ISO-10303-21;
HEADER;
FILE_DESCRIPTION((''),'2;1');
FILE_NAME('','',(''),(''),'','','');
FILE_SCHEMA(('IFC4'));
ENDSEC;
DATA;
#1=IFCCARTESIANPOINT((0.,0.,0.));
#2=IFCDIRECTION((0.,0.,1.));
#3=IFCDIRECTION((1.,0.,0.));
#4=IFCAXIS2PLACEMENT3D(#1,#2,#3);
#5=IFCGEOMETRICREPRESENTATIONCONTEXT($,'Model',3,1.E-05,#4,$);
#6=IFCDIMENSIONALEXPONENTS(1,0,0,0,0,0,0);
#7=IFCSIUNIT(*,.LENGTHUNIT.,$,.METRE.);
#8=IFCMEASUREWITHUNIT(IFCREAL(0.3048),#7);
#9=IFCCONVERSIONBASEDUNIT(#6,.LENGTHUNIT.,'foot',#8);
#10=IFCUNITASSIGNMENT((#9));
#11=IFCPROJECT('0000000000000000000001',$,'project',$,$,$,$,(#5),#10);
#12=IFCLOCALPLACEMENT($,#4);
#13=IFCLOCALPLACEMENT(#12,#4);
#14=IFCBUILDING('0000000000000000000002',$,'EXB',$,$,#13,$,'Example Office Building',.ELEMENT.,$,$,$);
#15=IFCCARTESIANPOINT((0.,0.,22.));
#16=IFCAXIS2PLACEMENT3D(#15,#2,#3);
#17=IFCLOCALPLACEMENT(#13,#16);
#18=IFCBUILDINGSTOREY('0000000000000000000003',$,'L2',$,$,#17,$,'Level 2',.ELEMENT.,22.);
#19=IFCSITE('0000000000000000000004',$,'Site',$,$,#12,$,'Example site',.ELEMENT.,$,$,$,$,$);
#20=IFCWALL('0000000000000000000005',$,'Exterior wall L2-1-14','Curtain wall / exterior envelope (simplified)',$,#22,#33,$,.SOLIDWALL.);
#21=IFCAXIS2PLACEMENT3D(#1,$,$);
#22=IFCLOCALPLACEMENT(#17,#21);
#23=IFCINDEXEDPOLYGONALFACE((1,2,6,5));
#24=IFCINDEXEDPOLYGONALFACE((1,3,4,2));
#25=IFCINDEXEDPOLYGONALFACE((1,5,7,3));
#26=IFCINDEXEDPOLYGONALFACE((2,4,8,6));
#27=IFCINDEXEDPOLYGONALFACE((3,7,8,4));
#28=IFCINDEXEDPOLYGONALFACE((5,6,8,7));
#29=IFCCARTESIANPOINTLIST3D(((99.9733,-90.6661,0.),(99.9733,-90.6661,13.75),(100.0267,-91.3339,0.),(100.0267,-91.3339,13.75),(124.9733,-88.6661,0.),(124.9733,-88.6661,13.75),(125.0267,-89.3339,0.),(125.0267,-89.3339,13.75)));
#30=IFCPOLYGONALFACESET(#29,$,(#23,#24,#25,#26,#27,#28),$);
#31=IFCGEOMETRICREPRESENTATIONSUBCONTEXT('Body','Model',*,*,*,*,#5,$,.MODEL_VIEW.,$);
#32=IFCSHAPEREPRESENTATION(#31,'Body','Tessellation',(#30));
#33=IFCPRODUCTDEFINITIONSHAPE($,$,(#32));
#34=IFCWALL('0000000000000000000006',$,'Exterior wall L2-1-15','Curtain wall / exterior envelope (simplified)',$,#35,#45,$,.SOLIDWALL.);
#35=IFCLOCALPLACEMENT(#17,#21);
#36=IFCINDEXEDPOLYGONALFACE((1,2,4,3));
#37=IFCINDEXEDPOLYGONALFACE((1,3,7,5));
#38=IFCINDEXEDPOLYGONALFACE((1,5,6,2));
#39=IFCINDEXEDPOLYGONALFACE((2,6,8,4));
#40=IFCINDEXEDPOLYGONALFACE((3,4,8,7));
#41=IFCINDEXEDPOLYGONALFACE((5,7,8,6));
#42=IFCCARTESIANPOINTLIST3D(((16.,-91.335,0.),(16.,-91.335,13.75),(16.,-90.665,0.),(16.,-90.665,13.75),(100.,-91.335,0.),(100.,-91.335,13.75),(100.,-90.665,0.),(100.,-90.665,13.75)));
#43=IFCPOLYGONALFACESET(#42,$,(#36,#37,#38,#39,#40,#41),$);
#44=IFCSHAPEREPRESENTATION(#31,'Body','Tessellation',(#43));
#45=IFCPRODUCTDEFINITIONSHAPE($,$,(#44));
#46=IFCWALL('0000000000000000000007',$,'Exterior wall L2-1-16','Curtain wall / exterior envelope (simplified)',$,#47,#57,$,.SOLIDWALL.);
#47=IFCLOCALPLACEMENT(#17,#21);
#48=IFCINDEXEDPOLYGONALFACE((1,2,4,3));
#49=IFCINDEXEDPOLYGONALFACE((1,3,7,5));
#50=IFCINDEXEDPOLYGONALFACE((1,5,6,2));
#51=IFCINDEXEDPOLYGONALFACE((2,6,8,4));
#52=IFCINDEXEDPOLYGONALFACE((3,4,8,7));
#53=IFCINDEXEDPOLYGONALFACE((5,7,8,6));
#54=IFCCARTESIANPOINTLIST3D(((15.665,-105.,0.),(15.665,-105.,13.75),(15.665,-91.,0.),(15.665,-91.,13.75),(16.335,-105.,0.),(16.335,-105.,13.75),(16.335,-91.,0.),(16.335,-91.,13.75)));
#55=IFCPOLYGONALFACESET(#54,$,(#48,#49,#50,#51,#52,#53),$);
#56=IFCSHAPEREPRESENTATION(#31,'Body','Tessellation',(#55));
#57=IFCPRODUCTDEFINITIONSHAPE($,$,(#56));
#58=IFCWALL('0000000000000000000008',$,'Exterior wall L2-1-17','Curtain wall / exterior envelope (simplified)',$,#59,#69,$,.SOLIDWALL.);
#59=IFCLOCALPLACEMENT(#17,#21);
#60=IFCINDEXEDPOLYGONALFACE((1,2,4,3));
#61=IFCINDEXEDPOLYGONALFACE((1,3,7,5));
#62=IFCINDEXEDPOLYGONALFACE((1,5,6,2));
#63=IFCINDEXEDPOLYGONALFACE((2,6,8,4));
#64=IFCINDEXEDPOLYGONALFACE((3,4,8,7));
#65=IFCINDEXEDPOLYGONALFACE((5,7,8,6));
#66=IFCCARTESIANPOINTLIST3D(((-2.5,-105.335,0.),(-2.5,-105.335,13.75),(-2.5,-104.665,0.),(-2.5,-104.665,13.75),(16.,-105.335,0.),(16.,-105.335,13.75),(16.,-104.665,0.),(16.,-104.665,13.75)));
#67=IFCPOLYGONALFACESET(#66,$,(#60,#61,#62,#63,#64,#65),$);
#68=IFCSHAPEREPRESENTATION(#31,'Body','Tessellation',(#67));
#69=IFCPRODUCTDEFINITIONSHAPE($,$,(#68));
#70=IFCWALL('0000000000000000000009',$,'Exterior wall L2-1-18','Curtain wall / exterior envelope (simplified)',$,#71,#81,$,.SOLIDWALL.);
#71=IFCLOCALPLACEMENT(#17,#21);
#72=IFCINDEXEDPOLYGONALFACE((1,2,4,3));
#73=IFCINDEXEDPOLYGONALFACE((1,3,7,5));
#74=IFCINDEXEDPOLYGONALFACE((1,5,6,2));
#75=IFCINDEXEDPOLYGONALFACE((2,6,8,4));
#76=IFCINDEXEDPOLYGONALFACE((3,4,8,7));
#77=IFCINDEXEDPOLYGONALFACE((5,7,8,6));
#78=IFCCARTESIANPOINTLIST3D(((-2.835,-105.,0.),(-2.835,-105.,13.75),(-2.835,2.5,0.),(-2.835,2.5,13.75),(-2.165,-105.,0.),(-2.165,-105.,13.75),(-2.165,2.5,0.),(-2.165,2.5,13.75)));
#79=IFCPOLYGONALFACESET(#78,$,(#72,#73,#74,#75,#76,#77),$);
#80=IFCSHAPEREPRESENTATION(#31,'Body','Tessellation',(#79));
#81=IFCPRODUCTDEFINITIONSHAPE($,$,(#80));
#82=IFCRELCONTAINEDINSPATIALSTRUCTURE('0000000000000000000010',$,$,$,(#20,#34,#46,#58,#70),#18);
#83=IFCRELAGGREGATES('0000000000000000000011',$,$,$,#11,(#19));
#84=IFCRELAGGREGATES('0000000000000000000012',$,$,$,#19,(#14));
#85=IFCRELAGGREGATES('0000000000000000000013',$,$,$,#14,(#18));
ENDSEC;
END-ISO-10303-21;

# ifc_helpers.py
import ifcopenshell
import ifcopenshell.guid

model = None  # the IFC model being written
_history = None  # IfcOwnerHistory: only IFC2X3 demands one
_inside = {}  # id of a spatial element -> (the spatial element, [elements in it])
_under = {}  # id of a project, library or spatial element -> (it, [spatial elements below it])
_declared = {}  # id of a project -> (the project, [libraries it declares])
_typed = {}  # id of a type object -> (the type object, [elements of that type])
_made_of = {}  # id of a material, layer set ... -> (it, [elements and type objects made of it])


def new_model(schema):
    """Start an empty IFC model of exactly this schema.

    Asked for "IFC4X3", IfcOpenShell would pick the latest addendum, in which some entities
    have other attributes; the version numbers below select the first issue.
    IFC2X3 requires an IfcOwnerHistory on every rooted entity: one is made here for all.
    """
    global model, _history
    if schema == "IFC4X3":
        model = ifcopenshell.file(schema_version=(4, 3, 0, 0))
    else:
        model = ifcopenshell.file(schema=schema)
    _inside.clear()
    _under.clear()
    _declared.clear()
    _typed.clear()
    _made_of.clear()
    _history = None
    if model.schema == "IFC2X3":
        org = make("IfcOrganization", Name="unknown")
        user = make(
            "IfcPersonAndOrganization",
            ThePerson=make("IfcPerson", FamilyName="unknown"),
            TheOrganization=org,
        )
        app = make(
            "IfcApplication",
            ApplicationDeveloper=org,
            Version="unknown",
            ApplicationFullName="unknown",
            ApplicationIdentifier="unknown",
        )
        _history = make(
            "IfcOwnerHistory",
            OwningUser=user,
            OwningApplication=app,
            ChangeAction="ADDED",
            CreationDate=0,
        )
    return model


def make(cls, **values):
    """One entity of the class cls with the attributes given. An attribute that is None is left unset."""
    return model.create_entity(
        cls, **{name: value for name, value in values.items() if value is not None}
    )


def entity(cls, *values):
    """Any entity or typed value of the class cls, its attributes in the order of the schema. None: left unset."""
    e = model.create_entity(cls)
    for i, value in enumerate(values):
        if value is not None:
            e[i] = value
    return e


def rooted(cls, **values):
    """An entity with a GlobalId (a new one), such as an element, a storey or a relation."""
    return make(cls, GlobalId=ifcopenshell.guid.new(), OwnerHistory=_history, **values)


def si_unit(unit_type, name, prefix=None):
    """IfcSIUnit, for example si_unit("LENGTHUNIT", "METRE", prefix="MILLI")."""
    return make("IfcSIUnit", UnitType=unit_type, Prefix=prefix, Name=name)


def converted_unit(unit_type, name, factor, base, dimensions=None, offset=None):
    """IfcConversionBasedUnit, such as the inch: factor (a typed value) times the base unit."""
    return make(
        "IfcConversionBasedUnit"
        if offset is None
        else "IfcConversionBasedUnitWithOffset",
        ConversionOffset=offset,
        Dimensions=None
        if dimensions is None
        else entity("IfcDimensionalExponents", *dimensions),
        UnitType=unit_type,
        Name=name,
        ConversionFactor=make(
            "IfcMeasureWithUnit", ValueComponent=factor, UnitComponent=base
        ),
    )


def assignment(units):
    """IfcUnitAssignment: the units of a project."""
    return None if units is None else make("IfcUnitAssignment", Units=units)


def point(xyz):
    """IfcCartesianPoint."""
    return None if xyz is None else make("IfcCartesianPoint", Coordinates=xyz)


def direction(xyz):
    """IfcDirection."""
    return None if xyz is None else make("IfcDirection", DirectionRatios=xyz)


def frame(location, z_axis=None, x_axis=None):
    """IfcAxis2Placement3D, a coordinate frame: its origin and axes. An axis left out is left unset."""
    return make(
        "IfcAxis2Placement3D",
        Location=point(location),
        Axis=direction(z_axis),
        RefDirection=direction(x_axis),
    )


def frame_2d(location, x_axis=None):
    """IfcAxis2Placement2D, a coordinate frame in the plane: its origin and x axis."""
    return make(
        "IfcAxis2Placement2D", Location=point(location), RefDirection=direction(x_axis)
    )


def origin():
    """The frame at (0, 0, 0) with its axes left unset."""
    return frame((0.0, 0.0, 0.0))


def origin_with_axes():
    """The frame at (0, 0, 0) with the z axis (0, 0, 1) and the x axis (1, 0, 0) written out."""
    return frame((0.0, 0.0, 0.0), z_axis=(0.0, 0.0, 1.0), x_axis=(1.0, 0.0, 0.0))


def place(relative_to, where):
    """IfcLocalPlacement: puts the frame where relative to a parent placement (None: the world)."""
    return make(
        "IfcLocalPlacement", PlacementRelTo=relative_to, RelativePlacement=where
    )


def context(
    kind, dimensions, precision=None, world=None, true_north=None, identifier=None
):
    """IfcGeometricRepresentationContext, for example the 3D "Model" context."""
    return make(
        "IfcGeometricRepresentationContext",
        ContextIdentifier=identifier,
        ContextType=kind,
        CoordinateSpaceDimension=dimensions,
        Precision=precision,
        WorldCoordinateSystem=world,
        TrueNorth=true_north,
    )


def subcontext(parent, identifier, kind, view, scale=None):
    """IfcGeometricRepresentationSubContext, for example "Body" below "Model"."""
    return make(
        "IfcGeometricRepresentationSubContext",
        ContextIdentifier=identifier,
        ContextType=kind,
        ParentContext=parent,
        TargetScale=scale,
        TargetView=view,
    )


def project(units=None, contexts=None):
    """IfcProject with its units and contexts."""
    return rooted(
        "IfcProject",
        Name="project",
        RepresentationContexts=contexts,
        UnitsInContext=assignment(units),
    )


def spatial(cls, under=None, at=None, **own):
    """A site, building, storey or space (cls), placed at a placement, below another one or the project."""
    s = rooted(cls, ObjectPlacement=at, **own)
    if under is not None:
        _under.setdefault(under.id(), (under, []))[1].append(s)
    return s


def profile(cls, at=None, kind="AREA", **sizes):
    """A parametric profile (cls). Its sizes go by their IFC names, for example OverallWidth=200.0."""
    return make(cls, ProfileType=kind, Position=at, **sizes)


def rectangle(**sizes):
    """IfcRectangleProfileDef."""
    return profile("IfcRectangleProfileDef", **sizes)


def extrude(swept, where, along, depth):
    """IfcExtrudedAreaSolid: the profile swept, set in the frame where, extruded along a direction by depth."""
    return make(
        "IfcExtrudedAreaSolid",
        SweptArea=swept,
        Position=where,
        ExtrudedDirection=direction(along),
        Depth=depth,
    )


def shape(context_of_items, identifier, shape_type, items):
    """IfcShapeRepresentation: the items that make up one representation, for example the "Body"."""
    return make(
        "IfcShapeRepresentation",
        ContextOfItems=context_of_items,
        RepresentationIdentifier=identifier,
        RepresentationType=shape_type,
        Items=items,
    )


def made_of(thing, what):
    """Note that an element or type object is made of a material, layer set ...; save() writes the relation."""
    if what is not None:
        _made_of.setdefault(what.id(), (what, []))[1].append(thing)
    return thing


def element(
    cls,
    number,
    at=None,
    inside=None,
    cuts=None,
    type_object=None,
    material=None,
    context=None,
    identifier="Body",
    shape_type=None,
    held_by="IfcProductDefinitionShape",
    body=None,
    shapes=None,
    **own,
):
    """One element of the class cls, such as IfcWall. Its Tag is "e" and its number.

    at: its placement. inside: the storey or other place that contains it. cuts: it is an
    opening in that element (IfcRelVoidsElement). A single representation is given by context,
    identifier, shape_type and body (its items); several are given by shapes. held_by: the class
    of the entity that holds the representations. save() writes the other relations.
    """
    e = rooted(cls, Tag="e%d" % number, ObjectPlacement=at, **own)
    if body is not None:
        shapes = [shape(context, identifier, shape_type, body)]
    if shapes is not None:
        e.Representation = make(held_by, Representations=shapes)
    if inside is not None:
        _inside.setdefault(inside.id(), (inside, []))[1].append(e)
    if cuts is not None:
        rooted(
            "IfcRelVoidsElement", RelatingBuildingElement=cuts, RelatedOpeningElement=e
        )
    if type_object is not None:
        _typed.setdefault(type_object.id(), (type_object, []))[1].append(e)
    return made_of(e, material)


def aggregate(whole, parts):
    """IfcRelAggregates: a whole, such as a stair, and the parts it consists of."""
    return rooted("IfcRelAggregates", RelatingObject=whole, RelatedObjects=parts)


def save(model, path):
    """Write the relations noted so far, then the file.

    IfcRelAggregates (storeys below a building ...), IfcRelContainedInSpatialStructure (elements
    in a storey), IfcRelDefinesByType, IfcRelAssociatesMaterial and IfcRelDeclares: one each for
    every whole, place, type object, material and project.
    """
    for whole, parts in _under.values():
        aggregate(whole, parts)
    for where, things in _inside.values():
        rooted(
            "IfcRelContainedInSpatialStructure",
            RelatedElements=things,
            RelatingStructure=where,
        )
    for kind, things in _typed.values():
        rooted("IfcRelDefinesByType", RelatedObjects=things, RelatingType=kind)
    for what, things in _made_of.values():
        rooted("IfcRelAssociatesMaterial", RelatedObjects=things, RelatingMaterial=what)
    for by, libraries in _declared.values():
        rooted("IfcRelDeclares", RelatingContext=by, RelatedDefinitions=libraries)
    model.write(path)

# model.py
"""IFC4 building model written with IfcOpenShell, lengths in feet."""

from ifc_helpers import new_model, entity, si_unit, converted_unit, frame, frame_2d, origin, origin_with_axes, place, context, subcontext, project, spatial, rectangle, extrude, element, save


model = new_model("IFC4")

# Units and contexts
model_context = context("Model", 3, precision=1e-05, world=origin_with_axes())
body_context = subcontext(model_context, "Body", "Model", "MODEL_VIEW")
ifc_project = project(units=[converted_unit("LENGTHUNIT", "foot", entity("IfcReal", 0.3048), si_unit("LENGTHUNIT", "METRE"), dimensions=[1, 0, 0, 0, 0, 0, 0])], contexts=[model_context])

# Site, building, storey
site_placement = place(None, origin_with_axes())
site = spatial("IfcSite", under=ifc_project, at=site_placement, Name="Site", LongName="Example site", CompositionType="ELEMENT")
building_placement = place(site_placement, origin_with_axes())
building = spatial("IfcBuilding", under=site, at=building_placement, Name="EXB", LongName="Example Office Building", CompositionType="ELEMENT")
storey_placement = place(building_placement, frame((0.0, 0.0, 22.0), z_axis=(0.0, 0.0, 1.0), x_axis=(1.0, 0.0, 0.0)))
storey = spatial("IfcBuildingStorey", under=building, at=storey_placement, Name="L2", LongName="Level 2", CompositionType="ELEMENT", Elevation=22.0)

# Walls
wall_1_placement = place(storey_placement, frame((125.0, -89.0, 0.0), z_axis=(0.0, 0.0, 1.0), x_axis=(-0.996815, -0.079745, 0.0)))
element("IfcWall", 1, at=wall_1_placement, inside=storey, Name="Exterior wall L2-1-14", Description="Curtain wall / exterior envelope (simplified)", PredefinedType="SOLIDWALL", context=body_context, shape_type="SweptSolid", body=[
    extrude(rectangle(XDim=25.0799, YDim=0.67, at=frame_2d((12.5399, 0.0))), origin(), (0.0, 0.0, 1.0), 13.75),
])
wall_2_placement = place(storey_placement, frame((100.0, -91.0, 0.0), z_axis=(0.0, 0.0, 1.0), x_axis=(-1.0, 0.0, 0.0)))
element("IfcWall", 2, at=wall_2_placement, inside=storey, Name="Exterior wall L2-1-15", Description="Curtain wall / exterior envelope (simplified)", PredefinedType="SOLIDWALL", context=body_context, shape_type="SweptSolid", body=[
    extrude(rectangle(XDim=84.0, YDim=0.67, at=frame_2d((42.0, 0.0))), origin(), (0.0, 0.0, 1.0), 13.75),
])
wall_3_placement = place(storey_placement, frame((16.0, -91.0, 0.0), z_axis=(0.0, 0.0, 1.0), x_axis=(0.0, -1.0, 0.0)))
element("IfcWall", 3, at=wall_3_placement, inside=storey, Name="Exterior wall L2-1-16", Description="Curtain wall / exterior envelope (simplified)", PredefinedType="SOLIDWALL", context=body_context, shape_type="SweptSolid", body=[
    extrude(rectangle(XDim=14.0, YDim=0.67, at=frame_2d((7.0, 0.0))), origin(), (0.0, 0.0, 1.0), 13.75),
])
wall_4_placement = place(storey_placement, frame((16.0, -105.0, 0.0), z_axis=(0.0, 0.0, 1.0), x_axis=(-1.0, 0.0, 0.0)))
element("IfcWall", 4, at=wall_4_placement, inside=storey, Name="Exterior wall L2-1-17", Description="Curtain wall / exterior envelope (simplified)", PredefinedType="SOLIDWALL", context=body_context, shape_type="SweptSolid", body=[
    extrude(rectangle(XDim=18.5, YDim=0.67, at=frame_2d((9.25, 0.0))), origin(), (0.0, 0.0, 1.0), 13.75),
])
wall_5_placement = place(storey_placement, frame((-2.5, -105.0, 0.0), z_axis=(0.0, 0.0, 1.0), x_axis=(0.0, 1.0, 0.0)))
element("IfcWall", 5, at=wall_5_placement, inside=storey, Name="Exterior wall L2-1-18", Description="Curtain wall / exterior envelope (simplified)", PredefinedType="SOLIDWALL", context=body_context, shape_type="SweptSolid", body=[
    extrude(rectangle(XDim=107.5, YDim=0.67, at=frame_2d((53.75, 0.0))), origin(), (0.0, 0.0, 1.0), 13.75),
])

save(model, "model.ifc")
